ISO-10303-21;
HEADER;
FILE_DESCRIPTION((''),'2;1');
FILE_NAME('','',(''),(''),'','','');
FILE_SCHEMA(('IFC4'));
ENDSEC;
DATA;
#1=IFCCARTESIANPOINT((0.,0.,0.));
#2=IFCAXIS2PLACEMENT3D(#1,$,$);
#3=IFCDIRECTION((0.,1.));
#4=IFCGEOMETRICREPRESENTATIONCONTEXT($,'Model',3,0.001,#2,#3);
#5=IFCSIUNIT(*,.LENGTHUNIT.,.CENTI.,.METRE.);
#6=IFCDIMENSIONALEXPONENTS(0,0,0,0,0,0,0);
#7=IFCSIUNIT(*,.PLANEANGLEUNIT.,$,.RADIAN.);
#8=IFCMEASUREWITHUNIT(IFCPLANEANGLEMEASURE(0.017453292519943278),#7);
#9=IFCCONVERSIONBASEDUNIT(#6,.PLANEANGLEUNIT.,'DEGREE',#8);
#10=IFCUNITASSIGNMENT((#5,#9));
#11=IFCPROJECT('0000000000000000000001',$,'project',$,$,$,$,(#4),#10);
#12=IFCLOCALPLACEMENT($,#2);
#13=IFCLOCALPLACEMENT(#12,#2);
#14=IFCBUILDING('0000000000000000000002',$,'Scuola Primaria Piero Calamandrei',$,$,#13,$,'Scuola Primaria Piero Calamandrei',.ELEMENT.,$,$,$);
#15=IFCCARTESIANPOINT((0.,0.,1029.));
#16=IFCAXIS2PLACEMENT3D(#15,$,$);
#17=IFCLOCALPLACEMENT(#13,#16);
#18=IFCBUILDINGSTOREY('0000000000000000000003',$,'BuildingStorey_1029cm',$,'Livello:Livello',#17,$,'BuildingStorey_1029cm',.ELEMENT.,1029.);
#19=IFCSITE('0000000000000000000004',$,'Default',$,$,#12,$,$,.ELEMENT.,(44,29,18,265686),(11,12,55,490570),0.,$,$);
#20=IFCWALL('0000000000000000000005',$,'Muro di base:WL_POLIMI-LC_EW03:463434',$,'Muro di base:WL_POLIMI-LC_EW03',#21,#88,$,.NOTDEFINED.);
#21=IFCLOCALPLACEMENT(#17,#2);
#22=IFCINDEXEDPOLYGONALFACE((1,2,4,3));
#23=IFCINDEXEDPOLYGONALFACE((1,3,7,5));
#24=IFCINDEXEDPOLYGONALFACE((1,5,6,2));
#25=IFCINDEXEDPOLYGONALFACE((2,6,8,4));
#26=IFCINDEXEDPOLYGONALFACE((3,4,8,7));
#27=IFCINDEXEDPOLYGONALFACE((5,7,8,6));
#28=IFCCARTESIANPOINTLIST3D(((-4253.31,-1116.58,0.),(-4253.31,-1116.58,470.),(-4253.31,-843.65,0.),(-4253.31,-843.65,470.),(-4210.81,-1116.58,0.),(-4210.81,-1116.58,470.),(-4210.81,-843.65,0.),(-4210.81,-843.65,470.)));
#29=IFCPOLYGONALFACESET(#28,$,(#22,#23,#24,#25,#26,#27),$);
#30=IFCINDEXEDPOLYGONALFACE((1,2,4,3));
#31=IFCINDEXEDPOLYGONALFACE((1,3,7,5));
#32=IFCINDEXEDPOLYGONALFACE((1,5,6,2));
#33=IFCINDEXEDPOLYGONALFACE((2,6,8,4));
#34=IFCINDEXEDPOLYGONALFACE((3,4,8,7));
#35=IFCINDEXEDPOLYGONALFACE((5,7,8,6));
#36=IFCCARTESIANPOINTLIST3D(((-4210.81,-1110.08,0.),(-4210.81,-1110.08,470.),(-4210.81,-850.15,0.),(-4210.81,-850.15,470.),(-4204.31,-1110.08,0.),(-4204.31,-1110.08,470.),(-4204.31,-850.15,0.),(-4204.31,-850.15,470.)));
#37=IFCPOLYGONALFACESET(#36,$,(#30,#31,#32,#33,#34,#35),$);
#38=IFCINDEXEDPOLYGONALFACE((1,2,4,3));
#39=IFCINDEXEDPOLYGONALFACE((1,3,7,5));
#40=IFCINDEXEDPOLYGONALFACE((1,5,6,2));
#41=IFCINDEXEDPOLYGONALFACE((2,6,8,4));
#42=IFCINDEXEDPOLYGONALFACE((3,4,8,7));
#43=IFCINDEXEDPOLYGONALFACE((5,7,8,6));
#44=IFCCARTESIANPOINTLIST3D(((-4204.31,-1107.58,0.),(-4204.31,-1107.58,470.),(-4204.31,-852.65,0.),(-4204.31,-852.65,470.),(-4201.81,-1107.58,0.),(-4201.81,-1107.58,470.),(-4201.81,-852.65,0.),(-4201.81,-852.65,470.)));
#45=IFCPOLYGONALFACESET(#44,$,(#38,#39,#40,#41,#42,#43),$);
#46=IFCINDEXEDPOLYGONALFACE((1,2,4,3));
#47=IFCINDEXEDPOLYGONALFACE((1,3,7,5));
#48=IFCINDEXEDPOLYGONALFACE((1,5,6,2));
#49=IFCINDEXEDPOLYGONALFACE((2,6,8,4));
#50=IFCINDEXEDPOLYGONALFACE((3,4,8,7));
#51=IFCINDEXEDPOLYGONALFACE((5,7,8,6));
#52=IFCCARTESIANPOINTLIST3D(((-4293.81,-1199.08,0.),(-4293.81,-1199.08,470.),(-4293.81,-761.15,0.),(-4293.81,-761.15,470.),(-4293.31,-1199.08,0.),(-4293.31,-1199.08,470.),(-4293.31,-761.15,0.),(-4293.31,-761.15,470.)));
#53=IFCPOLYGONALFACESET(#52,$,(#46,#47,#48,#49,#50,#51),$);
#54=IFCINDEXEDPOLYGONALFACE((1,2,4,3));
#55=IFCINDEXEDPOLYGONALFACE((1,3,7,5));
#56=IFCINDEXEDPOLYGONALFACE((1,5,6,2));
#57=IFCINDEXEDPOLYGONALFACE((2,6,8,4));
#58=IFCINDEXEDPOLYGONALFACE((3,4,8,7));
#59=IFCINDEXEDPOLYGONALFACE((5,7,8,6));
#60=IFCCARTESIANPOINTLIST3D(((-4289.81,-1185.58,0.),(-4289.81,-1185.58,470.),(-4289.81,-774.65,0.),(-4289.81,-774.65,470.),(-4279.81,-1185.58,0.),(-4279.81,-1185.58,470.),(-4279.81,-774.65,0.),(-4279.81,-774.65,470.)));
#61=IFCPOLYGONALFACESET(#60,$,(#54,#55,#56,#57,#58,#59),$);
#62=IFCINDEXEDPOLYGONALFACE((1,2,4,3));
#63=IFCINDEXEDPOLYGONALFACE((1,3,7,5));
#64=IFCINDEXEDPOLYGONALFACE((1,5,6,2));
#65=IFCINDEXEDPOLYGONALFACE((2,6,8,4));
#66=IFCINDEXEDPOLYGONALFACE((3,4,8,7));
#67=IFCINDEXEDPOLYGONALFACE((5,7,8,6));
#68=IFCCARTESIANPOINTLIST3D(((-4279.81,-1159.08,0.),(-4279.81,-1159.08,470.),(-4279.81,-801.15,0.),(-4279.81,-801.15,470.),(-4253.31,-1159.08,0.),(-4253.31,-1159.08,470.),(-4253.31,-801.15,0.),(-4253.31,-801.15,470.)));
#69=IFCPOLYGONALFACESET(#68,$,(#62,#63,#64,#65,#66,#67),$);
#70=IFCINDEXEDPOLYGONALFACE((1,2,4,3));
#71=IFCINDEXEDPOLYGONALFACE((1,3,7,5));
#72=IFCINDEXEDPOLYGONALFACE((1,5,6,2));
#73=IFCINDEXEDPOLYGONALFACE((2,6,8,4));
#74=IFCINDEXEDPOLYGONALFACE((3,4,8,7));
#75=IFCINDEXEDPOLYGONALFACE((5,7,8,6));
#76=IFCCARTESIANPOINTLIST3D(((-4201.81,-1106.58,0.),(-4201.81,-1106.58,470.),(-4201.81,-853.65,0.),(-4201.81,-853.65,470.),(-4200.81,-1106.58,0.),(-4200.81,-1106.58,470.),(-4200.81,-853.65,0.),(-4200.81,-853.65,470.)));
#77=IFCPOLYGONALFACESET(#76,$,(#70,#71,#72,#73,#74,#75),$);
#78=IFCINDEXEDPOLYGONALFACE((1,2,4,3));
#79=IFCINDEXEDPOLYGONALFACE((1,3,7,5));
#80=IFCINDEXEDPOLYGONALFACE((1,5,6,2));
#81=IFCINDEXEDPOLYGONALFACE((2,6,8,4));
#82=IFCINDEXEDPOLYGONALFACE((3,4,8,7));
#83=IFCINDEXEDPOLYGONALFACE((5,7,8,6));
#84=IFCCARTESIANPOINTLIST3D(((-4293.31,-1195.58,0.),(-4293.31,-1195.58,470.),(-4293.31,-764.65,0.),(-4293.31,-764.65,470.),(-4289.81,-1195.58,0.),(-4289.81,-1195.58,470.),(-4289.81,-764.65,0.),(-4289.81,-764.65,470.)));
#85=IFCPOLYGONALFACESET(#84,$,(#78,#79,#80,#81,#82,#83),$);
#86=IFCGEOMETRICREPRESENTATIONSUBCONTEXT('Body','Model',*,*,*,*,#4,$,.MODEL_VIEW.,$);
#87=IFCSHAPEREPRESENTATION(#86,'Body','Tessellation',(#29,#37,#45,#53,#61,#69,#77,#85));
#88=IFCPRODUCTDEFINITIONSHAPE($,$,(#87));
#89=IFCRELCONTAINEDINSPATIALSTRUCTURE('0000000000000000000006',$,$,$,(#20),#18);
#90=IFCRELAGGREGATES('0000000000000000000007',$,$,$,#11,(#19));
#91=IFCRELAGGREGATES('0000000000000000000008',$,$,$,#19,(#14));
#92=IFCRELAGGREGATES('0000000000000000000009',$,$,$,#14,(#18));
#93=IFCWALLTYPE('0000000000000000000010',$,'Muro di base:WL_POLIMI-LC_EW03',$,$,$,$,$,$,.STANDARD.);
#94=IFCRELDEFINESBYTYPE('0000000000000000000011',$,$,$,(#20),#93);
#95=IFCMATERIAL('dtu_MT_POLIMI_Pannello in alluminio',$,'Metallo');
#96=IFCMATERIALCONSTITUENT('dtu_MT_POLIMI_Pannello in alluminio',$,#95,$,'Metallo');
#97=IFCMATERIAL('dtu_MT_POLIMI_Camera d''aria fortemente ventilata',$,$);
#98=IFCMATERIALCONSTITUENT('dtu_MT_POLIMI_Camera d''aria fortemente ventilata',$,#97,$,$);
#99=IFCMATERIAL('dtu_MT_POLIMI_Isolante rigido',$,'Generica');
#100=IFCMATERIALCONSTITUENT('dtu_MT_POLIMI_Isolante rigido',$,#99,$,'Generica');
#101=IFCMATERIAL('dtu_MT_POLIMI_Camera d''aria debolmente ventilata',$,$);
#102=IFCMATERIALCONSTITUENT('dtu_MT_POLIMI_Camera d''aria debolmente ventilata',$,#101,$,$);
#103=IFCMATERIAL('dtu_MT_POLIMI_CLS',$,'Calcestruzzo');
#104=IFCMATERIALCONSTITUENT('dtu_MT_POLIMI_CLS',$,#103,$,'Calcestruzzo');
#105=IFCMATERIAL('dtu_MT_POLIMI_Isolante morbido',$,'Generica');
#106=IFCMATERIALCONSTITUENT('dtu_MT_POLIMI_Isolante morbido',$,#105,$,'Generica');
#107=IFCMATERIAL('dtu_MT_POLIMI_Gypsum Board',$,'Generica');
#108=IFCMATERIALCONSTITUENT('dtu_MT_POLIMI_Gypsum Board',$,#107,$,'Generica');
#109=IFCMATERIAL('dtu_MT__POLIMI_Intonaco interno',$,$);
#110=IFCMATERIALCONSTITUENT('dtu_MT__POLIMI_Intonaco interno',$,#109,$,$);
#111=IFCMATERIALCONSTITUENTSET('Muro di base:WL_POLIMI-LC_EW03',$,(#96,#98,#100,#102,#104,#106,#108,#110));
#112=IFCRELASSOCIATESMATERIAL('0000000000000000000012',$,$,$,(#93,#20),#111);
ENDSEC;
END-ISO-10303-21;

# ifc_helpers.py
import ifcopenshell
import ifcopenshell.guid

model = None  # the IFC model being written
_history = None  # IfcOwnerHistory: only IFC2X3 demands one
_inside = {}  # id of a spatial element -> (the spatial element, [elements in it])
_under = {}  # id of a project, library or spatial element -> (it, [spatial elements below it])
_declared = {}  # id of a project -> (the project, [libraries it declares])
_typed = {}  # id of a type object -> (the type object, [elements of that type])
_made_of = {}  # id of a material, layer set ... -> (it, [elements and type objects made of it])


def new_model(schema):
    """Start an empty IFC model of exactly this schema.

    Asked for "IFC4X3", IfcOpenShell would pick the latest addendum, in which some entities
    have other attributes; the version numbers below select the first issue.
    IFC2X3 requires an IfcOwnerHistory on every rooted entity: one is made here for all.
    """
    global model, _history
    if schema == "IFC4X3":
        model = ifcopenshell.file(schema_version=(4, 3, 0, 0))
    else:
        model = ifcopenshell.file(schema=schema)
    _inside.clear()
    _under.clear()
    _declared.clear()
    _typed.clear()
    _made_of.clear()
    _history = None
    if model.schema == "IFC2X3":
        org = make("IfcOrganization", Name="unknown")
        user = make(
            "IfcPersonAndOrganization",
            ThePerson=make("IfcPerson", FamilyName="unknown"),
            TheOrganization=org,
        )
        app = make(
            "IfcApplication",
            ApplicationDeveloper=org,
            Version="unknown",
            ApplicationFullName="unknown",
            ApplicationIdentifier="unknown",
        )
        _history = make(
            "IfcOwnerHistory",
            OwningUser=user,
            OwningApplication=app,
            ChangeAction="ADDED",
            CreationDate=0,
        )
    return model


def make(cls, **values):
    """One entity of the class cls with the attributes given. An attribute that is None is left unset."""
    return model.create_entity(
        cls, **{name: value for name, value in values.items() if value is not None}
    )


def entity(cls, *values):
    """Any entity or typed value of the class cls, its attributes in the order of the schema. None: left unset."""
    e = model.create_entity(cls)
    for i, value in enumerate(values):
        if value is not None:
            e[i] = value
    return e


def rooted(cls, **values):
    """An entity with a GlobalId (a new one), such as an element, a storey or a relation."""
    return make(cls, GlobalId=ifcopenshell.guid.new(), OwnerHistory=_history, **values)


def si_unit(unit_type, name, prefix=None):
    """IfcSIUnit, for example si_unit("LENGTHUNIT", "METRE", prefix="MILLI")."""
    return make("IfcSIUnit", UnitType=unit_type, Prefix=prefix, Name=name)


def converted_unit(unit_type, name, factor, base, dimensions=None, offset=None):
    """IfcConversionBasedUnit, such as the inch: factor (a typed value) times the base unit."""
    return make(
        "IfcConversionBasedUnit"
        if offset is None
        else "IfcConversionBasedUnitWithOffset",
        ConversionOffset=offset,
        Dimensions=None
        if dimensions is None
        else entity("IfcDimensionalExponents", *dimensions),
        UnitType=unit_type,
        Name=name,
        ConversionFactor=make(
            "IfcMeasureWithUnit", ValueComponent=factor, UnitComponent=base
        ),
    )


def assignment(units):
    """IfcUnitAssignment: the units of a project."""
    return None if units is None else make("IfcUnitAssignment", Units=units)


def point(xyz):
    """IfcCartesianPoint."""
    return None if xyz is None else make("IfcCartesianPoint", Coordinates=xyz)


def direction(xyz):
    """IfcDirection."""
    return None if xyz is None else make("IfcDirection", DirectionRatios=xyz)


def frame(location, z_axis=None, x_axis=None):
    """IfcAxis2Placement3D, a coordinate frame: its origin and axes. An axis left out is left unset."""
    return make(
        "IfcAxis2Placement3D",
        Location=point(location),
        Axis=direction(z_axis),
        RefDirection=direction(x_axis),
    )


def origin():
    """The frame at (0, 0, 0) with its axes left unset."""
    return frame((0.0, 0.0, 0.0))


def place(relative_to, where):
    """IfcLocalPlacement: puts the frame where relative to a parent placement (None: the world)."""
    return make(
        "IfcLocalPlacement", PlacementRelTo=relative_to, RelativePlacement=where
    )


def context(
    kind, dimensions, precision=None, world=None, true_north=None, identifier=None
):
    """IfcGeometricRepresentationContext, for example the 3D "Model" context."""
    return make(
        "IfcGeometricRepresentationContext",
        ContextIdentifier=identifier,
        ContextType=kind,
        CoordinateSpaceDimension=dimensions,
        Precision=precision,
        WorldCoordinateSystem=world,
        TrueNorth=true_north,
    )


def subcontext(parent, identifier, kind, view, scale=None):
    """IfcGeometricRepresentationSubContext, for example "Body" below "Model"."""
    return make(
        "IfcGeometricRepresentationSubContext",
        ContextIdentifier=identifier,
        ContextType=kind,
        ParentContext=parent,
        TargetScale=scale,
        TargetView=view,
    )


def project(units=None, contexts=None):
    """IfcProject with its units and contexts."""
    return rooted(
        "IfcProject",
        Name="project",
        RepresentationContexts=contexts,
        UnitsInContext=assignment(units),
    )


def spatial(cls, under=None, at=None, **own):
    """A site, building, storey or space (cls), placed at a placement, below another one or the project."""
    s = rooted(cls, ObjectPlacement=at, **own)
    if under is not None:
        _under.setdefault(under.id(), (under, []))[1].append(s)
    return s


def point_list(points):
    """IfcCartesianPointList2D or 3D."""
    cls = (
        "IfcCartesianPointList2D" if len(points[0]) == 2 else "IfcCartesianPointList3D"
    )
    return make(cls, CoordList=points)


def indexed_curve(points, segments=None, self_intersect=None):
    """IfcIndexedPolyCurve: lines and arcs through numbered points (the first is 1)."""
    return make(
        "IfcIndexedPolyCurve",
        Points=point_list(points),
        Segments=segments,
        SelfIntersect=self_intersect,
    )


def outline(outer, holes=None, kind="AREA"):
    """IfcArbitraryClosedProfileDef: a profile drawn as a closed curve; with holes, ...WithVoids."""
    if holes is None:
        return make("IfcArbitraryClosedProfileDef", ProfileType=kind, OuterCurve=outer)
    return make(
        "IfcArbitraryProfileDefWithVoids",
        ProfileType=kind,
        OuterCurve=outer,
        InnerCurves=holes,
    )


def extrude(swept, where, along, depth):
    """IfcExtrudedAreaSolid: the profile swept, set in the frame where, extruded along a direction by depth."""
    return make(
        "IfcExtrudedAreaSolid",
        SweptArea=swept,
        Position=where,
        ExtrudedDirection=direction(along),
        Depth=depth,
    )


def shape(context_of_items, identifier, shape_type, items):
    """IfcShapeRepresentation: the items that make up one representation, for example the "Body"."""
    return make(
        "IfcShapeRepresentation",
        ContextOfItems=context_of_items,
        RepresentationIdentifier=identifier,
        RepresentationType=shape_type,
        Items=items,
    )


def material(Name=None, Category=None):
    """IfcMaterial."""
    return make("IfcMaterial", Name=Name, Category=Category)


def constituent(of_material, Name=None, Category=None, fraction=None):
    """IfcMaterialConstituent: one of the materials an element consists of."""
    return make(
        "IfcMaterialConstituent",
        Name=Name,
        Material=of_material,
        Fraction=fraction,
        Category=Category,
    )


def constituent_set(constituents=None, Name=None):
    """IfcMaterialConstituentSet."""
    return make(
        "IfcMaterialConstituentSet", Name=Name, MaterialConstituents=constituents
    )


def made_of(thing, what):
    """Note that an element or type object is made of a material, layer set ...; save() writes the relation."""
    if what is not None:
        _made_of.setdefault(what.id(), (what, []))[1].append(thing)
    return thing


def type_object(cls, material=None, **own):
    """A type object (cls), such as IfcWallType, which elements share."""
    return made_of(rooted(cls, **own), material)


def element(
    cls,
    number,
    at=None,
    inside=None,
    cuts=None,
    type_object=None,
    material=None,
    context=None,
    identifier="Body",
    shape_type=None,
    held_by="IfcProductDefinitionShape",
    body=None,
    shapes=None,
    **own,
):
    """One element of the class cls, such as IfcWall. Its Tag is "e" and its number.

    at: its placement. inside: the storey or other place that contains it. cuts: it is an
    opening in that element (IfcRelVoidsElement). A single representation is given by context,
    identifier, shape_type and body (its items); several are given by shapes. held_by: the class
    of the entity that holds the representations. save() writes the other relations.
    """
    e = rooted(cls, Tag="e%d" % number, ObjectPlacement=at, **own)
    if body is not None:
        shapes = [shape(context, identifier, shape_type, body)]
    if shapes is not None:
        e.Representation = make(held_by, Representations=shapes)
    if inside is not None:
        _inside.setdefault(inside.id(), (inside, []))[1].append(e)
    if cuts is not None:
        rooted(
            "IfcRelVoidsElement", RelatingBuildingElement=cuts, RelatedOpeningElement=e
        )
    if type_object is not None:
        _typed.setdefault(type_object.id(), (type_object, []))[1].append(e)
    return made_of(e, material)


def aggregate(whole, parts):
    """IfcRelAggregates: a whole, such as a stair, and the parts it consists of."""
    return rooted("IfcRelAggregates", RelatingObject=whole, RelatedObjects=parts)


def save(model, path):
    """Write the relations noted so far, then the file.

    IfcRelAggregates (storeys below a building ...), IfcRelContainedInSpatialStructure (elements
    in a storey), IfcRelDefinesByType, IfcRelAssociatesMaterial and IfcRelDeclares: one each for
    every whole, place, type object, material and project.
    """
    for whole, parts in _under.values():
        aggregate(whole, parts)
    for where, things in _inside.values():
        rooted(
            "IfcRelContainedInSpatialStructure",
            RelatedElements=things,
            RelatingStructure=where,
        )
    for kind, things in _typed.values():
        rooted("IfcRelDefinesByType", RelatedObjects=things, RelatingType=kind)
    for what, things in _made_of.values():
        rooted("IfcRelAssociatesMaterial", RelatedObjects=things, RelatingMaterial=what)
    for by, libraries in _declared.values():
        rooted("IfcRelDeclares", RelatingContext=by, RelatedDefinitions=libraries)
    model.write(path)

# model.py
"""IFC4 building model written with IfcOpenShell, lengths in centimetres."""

from ifc_helpers import new_model, entity, si_unit, converted_unit, direction, frame, origin, place, context, subcontext, project, spatial, indexed_curve, outline, extrude, material, constituent, constituent_set, type_object, element, save


model = new_model("IFC4")

# Units and contexts
model_context = context("Model", 3, precision=0.001, world=origin(), true_north=direction((0.0, 1.0)))
body_context = subcontext(model_context, "Body", "Model", "MODEL_VIEW")
ifc_project = project(units=[si_unit("LENGTHUNIT", "METRE", prefix="CENTI"), converted_unit("PLANEANGLEUNIT", "DEGREE", entity("IfcPlaneAngleMeasure", 0.017453292519943278), si_unit("PLANEANGLEUNIT", "RADIAN"), dimensions=[0, 0, 0, 0, 0, 0, 0])], contexts=[model_context])

# Site, building, storey
site_placement = place(None, origin())
site = spatial("IfcSite", under=ifc_project, at=site_placement, Name="Default", CompositionType="ELEMENT", RefLatitude=(44, 29, 18, 265686), RefLongitude=(11, 12, 55, 490570), RefElevation=0.0)
building_placement = place(site_placement, origin())
building = spatial("IfcBuilding", under=site, at=building_placement, Name="Scuola Primaria Piero Calamandrei", LongName="Scuola Primaria Piero Calamandrei", CompositionType="ELEMENT")
storey_placement = place(building_placement, frame((0.0, 0.0, 1029.0)))
storey = spatial("IfcBuildingStorey", under=building, at=storey_placement, Name="BuildingStorey_1029cm", ObjectType="Livello:Livello", LongName="BuildingStorey_1029cm", CompositionType="ELEMENT", Elevation=1029.0)

# Shared definitions
ifc_material_1 = material(Name="dtu_MT_POLIMI_Isolante rigido", Category="Generica")
ifc_material_2 = material(Name="dtu_MT__POLIMI_Intonaco interno")

# Shared definitions
ifc_material_3 = material(Name="dtu_MT_POLIMI_CLS", Category="Calcestruzzo")

# Shared definitions
ifc_material_4 = material(Name="dtu_MT_POLIMI_Pannello in alluminio", Category="Metallo")
ifc_constituent_1 = constituent(ifc_material_4, Name="dtu_MT_POLIMI_Pannello in alluminio", Category="Metallo")
ifc_material_5 = material(Name="dtu_MT_POLIMI_Camera d'aria fortemente ventilata")
ifc_constituent_2 = constituent(ifc_material_5, Name="dtu_MT_POLIMI_Camera d'aria fortemente ventilata")
ifc_constituent_3 = constituent(ifc_material_1, Name="dtu_MT_POLIMI_Isolante rigido", Category="Generica")
ifc_material_6 = material(Name="dtu_MT_POLIMI_Camera d'aria debolmente ventilata")
ifc_constituent_4 = constituent(ifc_material_6, Name="dtu_MT_POLIMI_Camera d'aria debolmente ventilata")
ifc_constituent_5 = constituent(ifc_material_3, Name="dtu_MT_POLIMI_CLS", Category="Calcestruzzo")
ifc_material_7 = material(Name="dtu_MT_POLIMI_Isolante morbido", Category="Generica")
ifc_constituent_6 = constituent(ifc_material_7, Name="dtu_MT_POLIMI_Isolante morbido", Category="Generica")
ifc_material_8 = material(Name="dtu_MT_POLIMI_Gypsum Board", Category="Generica")
ifc_constituent_7 = constituent(ifc_material_8, Name="dtu_MT_POLIMI_Gypsum Board", Category="Generica")
ifc_constituent_8 = constituent(ifc_material_2, Name="dtu_MT__POLIMI_Intonaco interno")
ifc_constituent_set_1 = constituent_set(constituents=[ifc_constituent_1, ifc_constituent_2, ifc_constituent_3, ifc_constituent_4, ifc_constituent_5, ifc_constituent_6, ifc_constituent_7, ifc_constituent_8], Name="Muro di base:WL_POLIMI-LC_EW03")
wall_type = type_object("IfcWallType", Name="Muro di base:WL_POLIMI-LC_EW03", PredefinedType="STANDARD", material=ifc_constituent_set_1)

# Wall
wall_1_placement = place(storey_placement, frame((-4247.31, -1106.58, 0.0), z_axis=(0.0, 0.0, 1.0), x_axis=(0.0, 1.0, 0.0)))
element("IfcWall", 1, at=wall_1_placement, inside=storey, type_object=wall_type, material=ifc_constituent_set_1, Name="Muro di base:WL_POLIMI-LC_EW03:463434", ObjectType="Muro di base:WL_POLIMI-LC_EW03", PredefinedType="NOTDEFINED", context=body_context, shape_type="SweptSolid", body=[
    extrude(outline(indexed_curve([(-136.46, -21.25), (136.46, -21.25), (136.46, 21.25), (-136.46, 21.25), (-136.46, -21.25)], self_intersect=False)), frame((126.46, -15.25, 0.0)), (0.0, 0.0, 1.0), 470.0),
    extrude(outline(indexed_curve([(-129.96, -3.25), (129.96, -3.25), (129.96, 3.25), (-129.96, 3.25), (-129.96, -3.25)], self_intersect=False)), frame((126.46, -39.75, 0.0)), (0.0, 0.0, 1.0), 470.0),
    extrude(outline(indexed_curve([(-127.46, -1.25), (127.46, -1.25), (127.46, 1.25), (-127.46, 1.25), (-127.46, -1.25)], self_intersect=False)), frame((126.46, -44.25, 0.0)), (0.0, 0.0, 1.0), 470.0),
    extrude(outline(indexed_curve([(-0.25, -218.96), (0.25, -218.96), (0.25, 218.96), (-0.25, 218.96), (-0.25, -218.96)], self_intersect=False)), frame((126.46, 46.25, 0.0), z_axis=(0.0, 0.0, 1.0), x_axis=(0.0, -1.0, 0.0)), (0.0, 0.0, 1.0), 470.0),
    extrude(outline(indexed_curve([(-205.46, -5.0), (205.46, -5.0), (205.46, 5.0), (-205.46, 5.0), (-205.46, -5.0)], self_intersect=False)), frame((126.46, 37.5, 0.0)), (0.0, 0.0, 1.0), 470.0),
    extrude(outline(indexed_curve([(-178.96, -13.25), (178.96, -13.25), (178.96, 13.25), (-178.96, 13.25), (-178.96, -13.25)], self_intersect=False)), frame((126.46, 19.25, 0.0)), (0.0, 0.0, 1.0), 470.0),
    extrude(outline(indexed_curve([(-0.5, -126.46), (0.5, -126.46), (0.5, 126.46), (-0.5, 126.46), (-0.5, -126.46)], self_intersect=False)), frame((126.46, -46.0, 0.0), z_axis=(0.0, 0.0, 1.0), x_axis=(0.0, 1.0, 0.0)), (0.0, 0.0, 1.0), 470.0),
    extrude(outline(indexed_curve([(-215.46, -1.75), (215.46, -1.75), (215.46, 1.75), (-215.46, 1.75), (-215.46, -1.75)], self_intersect=False)), frame((126.46, 44.25, 0.0)), (0.0, 0.0, 1.0), 470.0),
])

save(model, "model.ifc")
